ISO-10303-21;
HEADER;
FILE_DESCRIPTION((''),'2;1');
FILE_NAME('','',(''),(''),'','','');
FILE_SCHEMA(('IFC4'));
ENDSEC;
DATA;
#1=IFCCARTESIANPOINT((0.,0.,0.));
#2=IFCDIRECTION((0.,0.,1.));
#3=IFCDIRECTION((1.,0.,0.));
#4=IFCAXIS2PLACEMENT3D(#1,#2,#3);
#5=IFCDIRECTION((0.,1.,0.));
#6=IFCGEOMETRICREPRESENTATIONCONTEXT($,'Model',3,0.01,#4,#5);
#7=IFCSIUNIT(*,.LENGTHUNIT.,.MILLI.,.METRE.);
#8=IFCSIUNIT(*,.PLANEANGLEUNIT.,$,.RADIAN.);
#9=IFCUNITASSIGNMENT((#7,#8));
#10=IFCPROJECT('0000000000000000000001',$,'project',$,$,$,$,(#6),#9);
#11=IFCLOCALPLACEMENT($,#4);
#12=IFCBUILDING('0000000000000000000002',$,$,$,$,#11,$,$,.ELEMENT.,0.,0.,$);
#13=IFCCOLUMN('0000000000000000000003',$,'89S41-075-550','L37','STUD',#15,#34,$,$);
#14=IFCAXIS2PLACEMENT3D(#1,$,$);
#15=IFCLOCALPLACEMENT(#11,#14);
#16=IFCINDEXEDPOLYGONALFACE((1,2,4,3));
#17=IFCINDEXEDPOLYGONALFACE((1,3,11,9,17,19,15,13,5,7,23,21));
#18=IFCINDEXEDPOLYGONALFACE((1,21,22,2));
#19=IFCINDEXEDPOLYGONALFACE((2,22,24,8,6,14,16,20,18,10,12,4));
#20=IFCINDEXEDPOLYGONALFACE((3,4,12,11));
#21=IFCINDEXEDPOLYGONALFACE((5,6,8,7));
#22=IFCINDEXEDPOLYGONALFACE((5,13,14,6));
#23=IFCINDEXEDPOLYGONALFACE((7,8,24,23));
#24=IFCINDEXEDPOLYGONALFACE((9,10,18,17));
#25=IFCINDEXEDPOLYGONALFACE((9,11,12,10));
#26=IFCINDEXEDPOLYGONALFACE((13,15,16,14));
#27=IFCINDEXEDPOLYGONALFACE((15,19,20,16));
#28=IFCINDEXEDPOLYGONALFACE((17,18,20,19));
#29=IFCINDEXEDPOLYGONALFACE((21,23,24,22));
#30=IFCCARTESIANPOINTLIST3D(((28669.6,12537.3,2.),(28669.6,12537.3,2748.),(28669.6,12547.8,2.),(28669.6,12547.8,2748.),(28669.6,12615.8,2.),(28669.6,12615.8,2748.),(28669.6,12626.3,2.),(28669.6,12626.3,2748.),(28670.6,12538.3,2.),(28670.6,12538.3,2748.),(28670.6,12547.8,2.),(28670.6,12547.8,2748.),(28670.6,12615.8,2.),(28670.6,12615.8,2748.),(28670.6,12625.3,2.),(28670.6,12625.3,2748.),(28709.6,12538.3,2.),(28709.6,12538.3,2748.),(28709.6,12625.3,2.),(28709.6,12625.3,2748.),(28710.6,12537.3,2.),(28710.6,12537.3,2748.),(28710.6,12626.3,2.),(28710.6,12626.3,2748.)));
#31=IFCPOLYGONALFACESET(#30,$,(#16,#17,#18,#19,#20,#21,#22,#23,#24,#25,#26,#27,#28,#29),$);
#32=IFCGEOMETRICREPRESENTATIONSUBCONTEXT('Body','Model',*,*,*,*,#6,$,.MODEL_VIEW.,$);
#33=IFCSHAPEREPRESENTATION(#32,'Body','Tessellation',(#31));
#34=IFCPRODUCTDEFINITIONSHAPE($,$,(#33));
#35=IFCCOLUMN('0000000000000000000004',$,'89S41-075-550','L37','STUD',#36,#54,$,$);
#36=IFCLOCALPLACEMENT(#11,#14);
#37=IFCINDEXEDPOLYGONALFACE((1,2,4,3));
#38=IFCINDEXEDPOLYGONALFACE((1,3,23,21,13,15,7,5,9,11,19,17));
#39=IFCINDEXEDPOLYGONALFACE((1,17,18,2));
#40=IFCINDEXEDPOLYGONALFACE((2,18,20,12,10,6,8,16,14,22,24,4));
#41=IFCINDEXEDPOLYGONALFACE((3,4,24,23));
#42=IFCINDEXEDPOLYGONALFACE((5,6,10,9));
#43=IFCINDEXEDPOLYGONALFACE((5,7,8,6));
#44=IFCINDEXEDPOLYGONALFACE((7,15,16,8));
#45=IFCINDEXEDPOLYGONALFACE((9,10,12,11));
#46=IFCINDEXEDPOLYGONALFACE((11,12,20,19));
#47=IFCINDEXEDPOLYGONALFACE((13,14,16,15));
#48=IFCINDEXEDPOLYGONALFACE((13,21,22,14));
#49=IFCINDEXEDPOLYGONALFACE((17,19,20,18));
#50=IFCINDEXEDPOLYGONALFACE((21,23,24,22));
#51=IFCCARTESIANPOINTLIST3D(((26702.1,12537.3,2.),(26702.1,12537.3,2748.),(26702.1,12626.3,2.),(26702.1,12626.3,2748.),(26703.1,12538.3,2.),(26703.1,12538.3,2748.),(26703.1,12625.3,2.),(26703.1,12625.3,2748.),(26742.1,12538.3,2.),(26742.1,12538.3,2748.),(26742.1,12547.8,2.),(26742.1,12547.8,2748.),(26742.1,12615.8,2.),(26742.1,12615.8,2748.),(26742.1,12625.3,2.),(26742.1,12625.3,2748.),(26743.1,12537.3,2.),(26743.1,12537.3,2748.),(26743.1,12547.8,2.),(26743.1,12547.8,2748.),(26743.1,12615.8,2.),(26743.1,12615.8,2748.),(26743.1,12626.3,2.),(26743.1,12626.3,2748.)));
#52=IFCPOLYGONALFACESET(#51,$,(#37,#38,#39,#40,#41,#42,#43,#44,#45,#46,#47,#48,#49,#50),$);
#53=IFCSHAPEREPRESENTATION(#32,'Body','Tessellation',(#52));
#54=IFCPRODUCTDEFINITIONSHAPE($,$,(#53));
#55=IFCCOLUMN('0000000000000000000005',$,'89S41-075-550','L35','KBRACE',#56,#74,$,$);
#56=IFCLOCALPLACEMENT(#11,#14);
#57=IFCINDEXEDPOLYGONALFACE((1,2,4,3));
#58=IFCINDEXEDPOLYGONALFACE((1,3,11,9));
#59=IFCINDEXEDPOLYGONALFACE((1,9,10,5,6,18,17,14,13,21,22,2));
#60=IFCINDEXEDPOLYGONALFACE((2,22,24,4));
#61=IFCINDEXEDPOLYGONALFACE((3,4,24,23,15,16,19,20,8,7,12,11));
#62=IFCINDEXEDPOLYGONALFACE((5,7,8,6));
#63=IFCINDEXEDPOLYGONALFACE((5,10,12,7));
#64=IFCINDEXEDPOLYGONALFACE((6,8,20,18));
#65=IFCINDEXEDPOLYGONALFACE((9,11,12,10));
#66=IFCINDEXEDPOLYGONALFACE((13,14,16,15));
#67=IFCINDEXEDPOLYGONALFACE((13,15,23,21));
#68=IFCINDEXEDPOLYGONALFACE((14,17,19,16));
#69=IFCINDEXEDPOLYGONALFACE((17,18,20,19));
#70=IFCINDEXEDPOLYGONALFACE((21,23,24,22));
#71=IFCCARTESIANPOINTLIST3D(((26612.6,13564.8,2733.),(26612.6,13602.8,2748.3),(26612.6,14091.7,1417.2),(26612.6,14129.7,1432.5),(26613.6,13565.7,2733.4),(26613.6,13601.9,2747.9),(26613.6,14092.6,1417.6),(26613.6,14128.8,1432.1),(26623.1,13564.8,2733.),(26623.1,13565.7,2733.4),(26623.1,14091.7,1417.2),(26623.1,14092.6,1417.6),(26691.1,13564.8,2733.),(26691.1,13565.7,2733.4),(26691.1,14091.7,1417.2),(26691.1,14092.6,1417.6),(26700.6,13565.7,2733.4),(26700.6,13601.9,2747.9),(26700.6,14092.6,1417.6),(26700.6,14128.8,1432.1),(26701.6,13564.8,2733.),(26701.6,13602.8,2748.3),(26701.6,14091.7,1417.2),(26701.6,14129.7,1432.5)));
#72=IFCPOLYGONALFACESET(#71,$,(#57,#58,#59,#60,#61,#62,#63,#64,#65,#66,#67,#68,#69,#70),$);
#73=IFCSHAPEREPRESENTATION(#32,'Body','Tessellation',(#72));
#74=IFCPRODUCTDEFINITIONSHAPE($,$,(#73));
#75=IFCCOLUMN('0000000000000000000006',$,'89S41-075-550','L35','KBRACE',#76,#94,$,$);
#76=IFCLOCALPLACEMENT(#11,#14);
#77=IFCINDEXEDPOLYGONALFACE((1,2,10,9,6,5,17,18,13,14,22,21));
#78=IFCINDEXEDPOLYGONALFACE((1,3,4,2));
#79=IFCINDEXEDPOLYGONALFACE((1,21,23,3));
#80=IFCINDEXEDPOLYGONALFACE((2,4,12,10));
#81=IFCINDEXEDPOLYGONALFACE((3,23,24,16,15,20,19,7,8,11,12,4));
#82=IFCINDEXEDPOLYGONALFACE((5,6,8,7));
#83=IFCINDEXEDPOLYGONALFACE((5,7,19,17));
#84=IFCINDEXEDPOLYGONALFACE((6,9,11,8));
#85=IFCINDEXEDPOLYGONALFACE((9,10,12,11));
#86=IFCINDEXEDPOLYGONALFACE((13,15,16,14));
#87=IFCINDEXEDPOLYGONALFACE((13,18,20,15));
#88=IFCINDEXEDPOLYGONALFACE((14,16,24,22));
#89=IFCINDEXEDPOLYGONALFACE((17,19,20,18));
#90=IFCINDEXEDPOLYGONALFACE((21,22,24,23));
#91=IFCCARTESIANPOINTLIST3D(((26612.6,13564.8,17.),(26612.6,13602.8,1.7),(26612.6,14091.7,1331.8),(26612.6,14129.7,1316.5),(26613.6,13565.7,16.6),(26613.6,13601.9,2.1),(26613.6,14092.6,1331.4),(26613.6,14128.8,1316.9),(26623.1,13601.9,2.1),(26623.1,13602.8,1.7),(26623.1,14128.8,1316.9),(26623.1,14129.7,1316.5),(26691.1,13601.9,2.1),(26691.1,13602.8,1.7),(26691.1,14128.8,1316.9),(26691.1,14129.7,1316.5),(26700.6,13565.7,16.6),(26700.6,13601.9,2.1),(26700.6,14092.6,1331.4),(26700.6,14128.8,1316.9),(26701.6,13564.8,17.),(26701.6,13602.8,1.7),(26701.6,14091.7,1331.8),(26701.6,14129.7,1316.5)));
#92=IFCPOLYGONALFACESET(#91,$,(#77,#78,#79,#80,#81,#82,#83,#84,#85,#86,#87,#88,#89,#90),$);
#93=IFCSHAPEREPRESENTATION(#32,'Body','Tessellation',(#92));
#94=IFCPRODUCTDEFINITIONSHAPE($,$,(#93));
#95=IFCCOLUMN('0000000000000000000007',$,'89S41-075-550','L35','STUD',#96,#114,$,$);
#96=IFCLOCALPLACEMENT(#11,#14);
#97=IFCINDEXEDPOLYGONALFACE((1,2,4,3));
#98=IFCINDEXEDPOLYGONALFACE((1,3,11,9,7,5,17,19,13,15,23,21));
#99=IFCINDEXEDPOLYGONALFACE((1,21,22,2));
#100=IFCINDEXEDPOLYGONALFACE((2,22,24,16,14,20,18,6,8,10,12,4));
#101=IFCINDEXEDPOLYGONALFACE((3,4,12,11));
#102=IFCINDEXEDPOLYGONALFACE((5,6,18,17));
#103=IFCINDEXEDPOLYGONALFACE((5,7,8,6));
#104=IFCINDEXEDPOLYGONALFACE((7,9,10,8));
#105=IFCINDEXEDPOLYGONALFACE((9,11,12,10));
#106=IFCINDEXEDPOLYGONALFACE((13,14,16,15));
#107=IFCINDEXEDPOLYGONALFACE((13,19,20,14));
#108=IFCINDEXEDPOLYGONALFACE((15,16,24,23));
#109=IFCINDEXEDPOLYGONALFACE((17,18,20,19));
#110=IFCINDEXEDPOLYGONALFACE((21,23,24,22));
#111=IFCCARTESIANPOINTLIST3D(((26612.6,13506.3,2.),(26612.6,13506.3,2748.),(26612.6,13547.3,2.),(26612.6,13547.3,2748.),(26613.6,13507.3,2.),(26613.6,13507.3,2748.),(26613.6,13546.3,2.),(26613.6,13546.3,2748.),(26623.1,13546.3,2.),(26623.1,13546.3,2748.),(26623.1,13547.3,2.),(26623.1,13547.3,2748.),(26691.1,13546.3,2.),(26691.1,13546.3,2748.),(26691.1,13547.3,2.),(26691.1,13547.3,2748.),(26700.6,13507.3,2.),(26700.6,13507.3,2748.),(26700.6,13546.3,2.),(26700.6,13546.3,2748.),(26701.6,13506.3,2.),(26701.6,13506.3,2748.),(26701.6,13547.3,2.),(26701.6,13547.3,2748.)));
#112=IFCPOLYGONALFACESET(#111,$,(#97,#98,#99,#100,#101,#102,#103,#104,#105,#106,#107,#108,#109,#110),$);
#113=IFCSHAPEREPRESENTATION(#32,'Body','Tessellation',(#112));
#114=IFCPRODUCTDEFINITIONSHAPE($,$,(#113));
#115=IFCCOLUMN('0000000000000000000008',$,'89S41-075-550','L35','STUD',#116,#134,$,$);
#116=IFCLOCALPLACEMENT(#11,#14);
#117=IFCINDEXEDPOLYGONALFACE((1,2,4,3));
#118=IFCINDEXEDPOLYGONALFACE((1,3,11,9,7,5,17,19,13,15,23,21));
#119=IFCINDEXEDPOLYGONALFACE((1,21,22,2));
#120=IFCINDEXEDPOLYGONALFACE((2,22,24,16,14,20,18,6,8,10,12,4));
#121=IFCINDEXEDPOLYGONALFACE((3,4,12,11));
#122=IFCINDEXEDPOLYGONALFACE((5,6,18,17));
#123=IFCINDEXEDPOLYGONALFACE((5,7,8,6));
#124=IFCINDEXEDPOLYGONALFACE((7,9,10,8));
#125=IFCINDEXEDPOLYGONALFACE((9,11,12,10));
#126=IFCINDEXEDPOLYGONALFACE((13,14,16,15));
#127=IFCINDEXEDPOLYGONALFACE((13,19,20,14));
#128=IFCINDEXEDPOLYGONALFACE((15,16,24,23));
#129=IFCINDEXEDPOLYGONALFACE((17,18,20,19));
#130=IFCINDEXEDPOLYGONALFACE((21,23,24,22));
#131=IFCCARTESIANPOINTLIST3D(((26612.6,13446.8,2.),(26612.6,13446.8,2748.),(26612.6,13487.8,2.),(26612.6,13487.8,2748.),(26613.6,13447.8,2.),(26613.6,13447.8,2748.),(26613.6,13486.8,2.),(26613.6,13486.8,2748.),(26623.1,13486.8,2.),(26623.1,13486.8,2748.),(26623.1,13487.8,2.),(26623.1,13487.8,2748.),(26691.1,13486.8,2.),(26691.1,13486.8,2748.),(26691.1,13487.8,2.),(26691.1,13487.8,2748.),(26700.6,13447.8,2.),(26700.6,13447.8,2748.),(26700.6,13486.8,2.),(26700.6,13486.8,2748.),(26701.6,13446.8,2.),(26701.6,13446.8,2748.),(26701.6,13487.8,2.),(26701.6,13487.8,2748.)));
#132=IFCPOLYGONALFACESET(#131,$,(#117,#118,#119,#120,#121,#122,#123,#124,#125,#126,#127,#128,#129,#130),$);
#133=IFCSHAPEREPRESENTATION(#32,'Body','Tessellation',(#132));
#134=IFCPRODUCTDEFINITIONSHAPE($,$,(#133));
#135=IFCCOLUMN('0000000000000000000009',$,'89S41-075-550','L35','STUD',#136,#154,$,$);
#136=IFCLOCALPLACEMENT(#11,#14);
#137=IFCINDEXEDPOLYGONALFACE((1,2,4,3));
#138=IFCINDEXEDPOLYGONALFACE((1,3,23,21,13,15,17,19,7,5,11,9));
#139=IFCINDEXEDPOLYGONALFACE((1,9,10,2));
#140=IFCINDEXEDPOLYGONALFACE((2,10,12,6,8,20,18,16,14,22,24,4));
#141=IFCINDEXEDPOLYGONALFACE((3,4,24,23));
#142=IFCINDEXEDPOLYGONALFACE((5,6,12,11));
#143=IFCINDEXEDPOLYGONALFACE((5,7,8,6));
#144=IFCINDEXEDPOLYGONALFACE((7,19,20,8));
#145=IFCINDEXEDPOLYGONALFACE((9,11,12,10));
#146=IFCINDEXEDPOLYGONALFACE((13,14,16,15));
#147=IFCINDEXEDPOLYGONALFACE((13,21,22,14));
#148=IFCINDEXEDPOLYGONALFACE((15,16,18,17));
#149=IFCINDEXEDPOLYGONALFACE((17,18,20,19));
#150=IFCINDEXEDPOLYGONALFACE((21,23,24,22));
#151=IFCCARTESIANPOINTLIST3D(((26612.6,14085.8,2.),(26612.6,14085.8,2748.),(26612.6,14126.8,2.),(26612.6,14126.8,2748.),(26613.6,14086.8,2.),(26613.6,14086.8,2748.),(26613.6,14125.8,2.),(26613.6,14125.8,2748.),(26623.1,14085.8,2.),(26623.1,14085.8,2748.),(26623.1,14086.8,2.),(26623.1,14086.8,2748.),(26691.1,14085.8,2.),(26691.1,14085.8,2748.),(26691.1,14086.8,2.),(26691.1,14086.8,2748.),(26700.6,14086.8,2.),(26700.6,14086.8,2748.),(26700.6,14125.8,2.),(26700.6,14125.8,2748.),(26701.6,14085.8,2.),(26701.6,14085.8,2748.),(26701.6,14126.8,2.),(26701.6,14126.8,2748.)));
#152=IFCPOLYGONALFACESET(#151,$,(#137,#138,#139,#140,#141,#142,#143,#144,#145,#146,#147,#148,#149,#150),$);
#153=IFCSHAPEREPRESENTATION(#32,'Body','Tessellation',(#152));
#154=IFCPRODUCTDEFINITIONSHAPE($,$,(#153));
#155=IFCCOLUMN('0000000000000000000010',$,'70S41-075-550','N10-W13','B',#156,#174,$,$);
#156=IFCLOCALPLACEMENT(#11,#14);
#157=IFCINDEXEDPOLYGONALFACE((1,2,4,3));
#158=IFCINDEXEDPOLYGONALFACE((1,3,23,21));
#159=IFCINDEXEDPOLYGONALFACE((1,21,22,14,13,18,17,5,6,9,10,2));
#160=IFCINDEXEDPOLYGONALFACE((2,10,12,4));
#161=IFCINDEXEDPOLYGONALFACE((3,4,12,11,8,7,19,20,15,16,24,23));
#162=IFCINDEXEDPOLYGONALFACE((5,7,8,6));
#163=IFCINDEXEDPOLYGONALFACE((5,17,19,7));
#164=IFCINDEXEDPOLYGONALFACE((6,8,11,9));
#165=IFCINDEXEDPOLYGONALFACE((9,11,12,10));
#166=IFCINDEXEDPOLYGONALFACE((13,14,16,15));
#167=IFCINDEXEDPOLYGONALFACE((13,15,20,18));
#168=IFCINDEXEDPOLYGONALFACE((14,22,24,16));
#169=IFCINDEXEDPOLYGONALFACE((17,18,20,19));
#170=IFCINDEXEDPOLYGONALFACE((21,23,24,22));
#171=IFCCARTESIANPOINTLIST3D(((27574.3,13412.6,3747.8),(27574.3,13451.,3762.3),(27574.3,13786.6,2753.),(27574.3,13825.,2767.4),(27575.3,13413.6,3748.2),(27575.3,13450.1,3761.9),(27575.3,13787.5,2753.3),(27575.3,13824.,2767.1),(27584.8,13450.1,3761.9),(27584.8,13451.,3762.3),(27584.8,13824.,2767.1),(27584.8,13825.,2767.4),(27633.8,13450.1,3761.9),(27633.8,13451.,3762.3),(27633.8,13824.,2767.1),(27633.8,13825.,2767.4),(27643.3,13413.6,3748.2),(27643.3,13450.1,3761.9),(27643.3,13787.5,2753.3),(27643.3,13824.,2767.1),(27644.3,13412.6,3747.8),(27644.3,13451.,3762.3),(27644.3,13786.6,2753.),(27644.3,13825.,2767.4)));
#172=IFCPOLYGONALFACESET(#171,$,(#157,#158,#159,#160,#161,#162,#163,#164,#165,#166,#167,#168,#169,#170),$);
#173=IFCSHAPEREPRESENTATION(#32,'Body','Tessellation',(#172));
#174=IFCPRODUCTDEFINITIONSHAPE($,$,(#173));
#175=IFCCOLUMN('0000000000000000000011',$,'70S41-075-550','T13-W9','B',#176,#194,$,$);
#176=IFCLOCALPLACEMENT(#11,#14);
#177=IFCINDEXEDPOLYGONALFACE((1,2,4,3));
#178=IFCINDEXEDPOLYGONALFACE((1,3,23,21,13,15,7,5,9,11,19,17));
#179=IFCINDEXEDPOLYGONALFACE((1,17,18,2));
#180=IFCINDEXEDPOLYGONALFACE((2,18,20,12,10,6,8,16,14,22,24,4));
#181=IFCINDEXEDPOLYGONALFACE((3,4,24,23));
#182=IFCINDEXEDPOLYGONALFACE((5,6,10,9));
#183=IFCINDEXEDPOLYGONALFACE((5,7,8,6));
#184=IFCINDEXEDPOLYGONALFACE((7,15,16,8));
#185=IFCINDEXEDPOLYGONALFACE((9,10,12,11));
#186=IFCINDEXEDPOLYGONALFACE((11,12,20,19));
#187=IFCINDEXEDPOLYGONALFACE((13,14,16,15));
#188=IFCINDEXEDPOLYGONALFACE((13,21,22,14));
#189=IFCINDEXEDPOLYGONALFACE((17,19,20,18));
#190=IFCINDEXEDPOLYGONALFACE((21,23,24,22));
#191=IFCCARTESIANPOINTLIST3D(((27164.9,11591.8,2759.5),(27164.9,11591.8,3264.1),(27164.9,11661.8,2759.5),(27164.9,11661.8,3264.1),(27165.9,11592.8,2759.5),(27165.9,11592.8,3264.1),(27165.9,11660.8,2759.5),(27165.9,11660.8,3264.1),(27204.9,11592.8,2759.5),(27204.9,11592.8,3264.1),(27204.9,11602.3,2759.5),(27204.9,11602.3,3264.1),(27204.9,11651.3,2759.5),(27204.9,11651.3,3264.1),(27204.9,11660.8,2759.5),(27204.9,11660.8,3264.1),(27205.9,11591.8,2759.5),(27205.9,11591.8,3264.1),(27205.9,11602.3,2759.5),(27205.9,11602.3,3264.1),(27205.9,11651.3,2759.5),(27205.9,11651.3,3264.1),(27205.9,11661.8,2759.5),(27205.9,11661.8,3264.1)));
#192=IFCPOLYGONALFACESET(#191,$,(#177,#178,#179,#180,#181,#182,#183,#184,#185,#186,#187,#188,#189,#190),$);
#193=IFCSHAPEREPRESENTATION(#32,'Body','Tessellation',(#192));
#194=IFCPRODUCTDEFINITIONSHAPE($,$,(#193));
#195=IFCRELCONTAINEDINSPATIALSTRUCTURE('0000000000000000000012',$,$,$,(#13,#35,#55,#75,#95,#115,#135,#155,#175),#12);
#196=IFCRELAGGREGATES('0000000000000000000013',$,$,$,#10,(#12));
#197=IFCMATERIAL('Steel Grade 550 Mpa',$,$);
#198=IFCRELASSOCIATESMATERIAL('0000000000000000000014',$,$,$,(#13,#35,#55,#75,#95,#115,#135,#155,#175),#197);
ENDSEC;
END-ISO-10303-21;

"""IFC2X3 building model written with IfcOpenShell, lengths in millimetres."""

from ifc_helpers import new_model, si_unit, direction, frame, origin, origin_with_axes, origin_2d_with_axis, place, context, subcontext, project, spatial, c_section, extrude, source, transform, mapped, material, element, save


model = new_model("IFC2X3")

# Units and contexts
model_context = context("Model", 3, precision=0.01, world=origin_with_axes(), true_north=direction((0.0, 1.0, 0.0)))
body_context = subcontext(model_context, "Body", "Model", "MODEL_VIEW")
ifc_project = project(units=[si_unit("LENGTHUNIT", "METRE", prefix="MILLI"), si_unit("PLANEANGLEUNIT", "RADIAN")], contexts=[model_context])

# Building
building_placement = place(None, origin_with_axes())
building = spatial("IfcBuilding", under=ifc_project, at=building_placement, CompositionType="ELEMENT", ElevationOfRefHeight=0.0, ElevationOfTerrain=0.0)

# Columns
ifc_material = material(Name="Steel Grade 550 Mpa")
shared_shape_1 = source(origin(), body_context, "Body", "SweptSolid", [
    extrude(c_section(Depth=89.0, Width=41.0, WallThickness=1.0, Girth=10.5, at=origin_2d_with_axis()), origin_with_axes(), (0.0, 0.0, 1.0), 2746.0),
])
column_1_placement = place(None, frame((28690.1, 12581.8, 2.0), z_axis=(0.0, 0.0, 1.0), x_axis=(-1.0, 0.0, 0.0)))
element("IfcColumn", 1, at=column_1_placement, inside=building, material=ifc_material, Name="89S41-075-550", Description="L37", ObjectType="STUD", context=body_context, shape_type="MappedRepresentation", body=[
    mapped(shared_shape_1, transform((0.0, 0.0, 0.0), scale=1.0)),
])
shared_shape_2 = source(origin(), body_context, "Body", "SweptSolid", [
    extrude(c_section(Depth=89.0, Width=41.0, WallThickness=1.0, Girth=10.5, at=origin_2d_with_axis()), origin_with_axes(), (0.0, 0.0, 1.0), 2746.0),
])
column_2_placement = place(None, frame((26722.6, 12581.8, 2.0), z_axis=(0.0, 0.0, 1.0), x_axis=(1.0, 0.0, 0.0)))
element("IfcColumn", 2, at=column_2_placement, inside=building, material=ifc_material, Name="89S41-075-550", Description="L37", ObjectType="STUD", context=body_context, shape_type="MappedRepresentation", body=[
    mapped(shared_shape_2, transform((0.0, 0.0, 0.0), scale=1.0)),
])
shared_shape_3 = source(origin(), body_context, "Body", "SweptSolid", [
    extrude(c_section(Depth=89.0, Width=41.0, WallThickness=1.0, Girth=10.5, at=origin_2d_with_axis()), origin_with_axes(), (0.0, 0.0, 1.0), 1417.4),
])
column_3_placement = place(None, frame((26657.1, 14110.7, 1424.9), z_axis=(0.0, -0.371762, 0.928328), x_axis=(0.0, -0.928328, -0.371762)))
element("IfcColumn", 3, at=column_3_placement, inside=building, material=ifc_material, Name="89S41-075-550", Description="L35", ObjectType="KBRACE", context=body_context, shape_type="MappedRepresentation", body=[
    mapped(shared_shape_3, transform((0.0, 0.0, 0.0), scale=1.0)),
])
shared_shape_4 = source(origin(), body_context, "Body", "SweptSolid", [
    extrude(c_section(Depth=89.0, Width=41.0, WallThickness=1.0, Girth=10.5, at=origin_2d_with_axis()), origin_with_axes(), (0.0, 0.0, 1.0), 1416.4),
])
column_4_placement = place(None, frame((26657.1, 13583.8, 9.4), z_axis=(0.0, 0.37201, 0.928229), x_axis=(0.0, 0.928229, -0.37201)))
element("IfcColumn", 4, at=column_4_placement, inside=building, material=ifc_material, Name="89S41-075-550", Description="L35", ObjectType="KBRACE", context=body_context, shape_type="MappedRepresentation", body=[
    mapped(shared_shape_4, transform((0.0, 0.0, 0.0), scale=1.0)),
])
shared_shape_5 = source(origin(), body_context, "Body", "SweptSolid", [
    extrude(c_section(Depth=89.0, Width=41.0, WallThickness=1.0, Girth=10.5, at=origin_2d_with_axis()), origin_with_axes(), (0.0, 0.0, 1.0), 2746.0),
])
column_5_placement = place(None, frame((26657.1, 13526.8, 2.0), z_axis=(0.0, 0.0, 1.0), x_axis=(0.0, 1.0, 0.0)))
element("IfcColumn", 5, at=column_5_placement, inside=building, material=ifc_material, Name="89S41-075-550", Description="L35", ObjectType="STUD", context=body_context, shape_type="MappedRepresentation", body=[
    mapped(shared_shape_5, transform((0.0, 0.0, 0.0), scale=1.0)),
])
shared_shape_6 = source(origin(), body_context, "Body", "SweptSolid", [
    extrude(c_section(Depth=89.0, Width=41.0, WallThickness=1.0, Girth=10.5, at=origin_2d_with_axis()), origin_with_axes(), (0.0, 0.0, 1.0), 2746.0),
])
column_6_placement = place(None, frame((26657.1, 13467.3, 2.0), z_axis=(0.0, 0.0, 1.0), x_axis=(0.0, 1.0, 0.0)))
element("IfcColumn", 6, at=column_6_placement, inside=building, material=ifc_material, Name="89S41-075-550", Description="L35", ObjectType="STUD", context=body_context, shape_type="MappedRepresentation", body=[
    mapped(shared_shape_6, transform((0.0, 0.0, 0.0), scale=1.0)),
])
shared_shape_7 = source(origin(), body_context, "Body", "SweptSolid", [
    extrude(c_section(Depth=89.0, Width=41.0, WallThickness=1.0, Girth=10.5, at=origin_2d_with_axis()), origin_with_axes(), (0.0, 0.0, 1.0), 2746.0),
])
column_7_placement = place(None, frame((26657.1, 14106.3, 2.0), z_axis=(0.0, 0.0, 1.0), x_axis=(0.0, -1.0, 0.0)))
element("IfcColumn", 7, at=column_7_placement, inside=building, material=ifc_material, Name="89S41-075-550", Description="L35", ObjectType="STUD", context=body_context, shape_type="MappedRepresentation", body=[
    mapped(shared_shape_7, transform((0.0, 0.0, 0.0), scale=1.0)),
])
shared_shape_8 = source(origin(), body_context, "Body", "SweptSolid", [
    extrude(c_section(Depth=70.0, Width=41.0, WallThickness=1.0, Girth=10.5, at=origin_2d_with_axis()), origin_with_axes(), (0.0, 0.0, 1.0), 1062.8),
])
column_8_placement = place(None, frame((27609.3, 13805.8, 2760.2), z_axis=(0.0, -0.351878, 0.936046), x_axis=(0.0, 0.936046, 0.351878)))
element("IfcColumn", 8, at=column_8_placement, inside=building, material=ifc_material, Name="70S41-075-550", Description="N10-W13", ObjectType="B", context=body_context, shape_type="MappedRepresentation", body=[
    mapped(shared_shape_8, transform((0.0, 0.0, 0.0), scale=1.0)),
])
shared_shape_9 = source(origin(), body_context, "Body", "SweptSolid", [
    extrude(c_section(Depth=70.0, Width=41.0, WallThickness=1.0, Girth=10.5, at=origin_2d_with_axis()), origin_with_axes(), (0.0, 0.0, 1.0), 504.6),
])
column_9_placement = place(None, frame((27185.4, 11626.8, 2759.5), z_axis=(0.0, 0.0, 1.0), x_axis=(1.0, 0.0, 0.0)))
element("IfcColumn", 9, at=column_9_placement, inside=building, material=ifc_material, Name="70S41-075-550", Description="T13-W9", ObjectType="B", context=body_context, shape_type="MappedRepresentation", body=[
    mapped(shared_shape_9, transform((0.0, 0.0, 0.0), scale=1.0)),
])

save(model, "model.ifc")
